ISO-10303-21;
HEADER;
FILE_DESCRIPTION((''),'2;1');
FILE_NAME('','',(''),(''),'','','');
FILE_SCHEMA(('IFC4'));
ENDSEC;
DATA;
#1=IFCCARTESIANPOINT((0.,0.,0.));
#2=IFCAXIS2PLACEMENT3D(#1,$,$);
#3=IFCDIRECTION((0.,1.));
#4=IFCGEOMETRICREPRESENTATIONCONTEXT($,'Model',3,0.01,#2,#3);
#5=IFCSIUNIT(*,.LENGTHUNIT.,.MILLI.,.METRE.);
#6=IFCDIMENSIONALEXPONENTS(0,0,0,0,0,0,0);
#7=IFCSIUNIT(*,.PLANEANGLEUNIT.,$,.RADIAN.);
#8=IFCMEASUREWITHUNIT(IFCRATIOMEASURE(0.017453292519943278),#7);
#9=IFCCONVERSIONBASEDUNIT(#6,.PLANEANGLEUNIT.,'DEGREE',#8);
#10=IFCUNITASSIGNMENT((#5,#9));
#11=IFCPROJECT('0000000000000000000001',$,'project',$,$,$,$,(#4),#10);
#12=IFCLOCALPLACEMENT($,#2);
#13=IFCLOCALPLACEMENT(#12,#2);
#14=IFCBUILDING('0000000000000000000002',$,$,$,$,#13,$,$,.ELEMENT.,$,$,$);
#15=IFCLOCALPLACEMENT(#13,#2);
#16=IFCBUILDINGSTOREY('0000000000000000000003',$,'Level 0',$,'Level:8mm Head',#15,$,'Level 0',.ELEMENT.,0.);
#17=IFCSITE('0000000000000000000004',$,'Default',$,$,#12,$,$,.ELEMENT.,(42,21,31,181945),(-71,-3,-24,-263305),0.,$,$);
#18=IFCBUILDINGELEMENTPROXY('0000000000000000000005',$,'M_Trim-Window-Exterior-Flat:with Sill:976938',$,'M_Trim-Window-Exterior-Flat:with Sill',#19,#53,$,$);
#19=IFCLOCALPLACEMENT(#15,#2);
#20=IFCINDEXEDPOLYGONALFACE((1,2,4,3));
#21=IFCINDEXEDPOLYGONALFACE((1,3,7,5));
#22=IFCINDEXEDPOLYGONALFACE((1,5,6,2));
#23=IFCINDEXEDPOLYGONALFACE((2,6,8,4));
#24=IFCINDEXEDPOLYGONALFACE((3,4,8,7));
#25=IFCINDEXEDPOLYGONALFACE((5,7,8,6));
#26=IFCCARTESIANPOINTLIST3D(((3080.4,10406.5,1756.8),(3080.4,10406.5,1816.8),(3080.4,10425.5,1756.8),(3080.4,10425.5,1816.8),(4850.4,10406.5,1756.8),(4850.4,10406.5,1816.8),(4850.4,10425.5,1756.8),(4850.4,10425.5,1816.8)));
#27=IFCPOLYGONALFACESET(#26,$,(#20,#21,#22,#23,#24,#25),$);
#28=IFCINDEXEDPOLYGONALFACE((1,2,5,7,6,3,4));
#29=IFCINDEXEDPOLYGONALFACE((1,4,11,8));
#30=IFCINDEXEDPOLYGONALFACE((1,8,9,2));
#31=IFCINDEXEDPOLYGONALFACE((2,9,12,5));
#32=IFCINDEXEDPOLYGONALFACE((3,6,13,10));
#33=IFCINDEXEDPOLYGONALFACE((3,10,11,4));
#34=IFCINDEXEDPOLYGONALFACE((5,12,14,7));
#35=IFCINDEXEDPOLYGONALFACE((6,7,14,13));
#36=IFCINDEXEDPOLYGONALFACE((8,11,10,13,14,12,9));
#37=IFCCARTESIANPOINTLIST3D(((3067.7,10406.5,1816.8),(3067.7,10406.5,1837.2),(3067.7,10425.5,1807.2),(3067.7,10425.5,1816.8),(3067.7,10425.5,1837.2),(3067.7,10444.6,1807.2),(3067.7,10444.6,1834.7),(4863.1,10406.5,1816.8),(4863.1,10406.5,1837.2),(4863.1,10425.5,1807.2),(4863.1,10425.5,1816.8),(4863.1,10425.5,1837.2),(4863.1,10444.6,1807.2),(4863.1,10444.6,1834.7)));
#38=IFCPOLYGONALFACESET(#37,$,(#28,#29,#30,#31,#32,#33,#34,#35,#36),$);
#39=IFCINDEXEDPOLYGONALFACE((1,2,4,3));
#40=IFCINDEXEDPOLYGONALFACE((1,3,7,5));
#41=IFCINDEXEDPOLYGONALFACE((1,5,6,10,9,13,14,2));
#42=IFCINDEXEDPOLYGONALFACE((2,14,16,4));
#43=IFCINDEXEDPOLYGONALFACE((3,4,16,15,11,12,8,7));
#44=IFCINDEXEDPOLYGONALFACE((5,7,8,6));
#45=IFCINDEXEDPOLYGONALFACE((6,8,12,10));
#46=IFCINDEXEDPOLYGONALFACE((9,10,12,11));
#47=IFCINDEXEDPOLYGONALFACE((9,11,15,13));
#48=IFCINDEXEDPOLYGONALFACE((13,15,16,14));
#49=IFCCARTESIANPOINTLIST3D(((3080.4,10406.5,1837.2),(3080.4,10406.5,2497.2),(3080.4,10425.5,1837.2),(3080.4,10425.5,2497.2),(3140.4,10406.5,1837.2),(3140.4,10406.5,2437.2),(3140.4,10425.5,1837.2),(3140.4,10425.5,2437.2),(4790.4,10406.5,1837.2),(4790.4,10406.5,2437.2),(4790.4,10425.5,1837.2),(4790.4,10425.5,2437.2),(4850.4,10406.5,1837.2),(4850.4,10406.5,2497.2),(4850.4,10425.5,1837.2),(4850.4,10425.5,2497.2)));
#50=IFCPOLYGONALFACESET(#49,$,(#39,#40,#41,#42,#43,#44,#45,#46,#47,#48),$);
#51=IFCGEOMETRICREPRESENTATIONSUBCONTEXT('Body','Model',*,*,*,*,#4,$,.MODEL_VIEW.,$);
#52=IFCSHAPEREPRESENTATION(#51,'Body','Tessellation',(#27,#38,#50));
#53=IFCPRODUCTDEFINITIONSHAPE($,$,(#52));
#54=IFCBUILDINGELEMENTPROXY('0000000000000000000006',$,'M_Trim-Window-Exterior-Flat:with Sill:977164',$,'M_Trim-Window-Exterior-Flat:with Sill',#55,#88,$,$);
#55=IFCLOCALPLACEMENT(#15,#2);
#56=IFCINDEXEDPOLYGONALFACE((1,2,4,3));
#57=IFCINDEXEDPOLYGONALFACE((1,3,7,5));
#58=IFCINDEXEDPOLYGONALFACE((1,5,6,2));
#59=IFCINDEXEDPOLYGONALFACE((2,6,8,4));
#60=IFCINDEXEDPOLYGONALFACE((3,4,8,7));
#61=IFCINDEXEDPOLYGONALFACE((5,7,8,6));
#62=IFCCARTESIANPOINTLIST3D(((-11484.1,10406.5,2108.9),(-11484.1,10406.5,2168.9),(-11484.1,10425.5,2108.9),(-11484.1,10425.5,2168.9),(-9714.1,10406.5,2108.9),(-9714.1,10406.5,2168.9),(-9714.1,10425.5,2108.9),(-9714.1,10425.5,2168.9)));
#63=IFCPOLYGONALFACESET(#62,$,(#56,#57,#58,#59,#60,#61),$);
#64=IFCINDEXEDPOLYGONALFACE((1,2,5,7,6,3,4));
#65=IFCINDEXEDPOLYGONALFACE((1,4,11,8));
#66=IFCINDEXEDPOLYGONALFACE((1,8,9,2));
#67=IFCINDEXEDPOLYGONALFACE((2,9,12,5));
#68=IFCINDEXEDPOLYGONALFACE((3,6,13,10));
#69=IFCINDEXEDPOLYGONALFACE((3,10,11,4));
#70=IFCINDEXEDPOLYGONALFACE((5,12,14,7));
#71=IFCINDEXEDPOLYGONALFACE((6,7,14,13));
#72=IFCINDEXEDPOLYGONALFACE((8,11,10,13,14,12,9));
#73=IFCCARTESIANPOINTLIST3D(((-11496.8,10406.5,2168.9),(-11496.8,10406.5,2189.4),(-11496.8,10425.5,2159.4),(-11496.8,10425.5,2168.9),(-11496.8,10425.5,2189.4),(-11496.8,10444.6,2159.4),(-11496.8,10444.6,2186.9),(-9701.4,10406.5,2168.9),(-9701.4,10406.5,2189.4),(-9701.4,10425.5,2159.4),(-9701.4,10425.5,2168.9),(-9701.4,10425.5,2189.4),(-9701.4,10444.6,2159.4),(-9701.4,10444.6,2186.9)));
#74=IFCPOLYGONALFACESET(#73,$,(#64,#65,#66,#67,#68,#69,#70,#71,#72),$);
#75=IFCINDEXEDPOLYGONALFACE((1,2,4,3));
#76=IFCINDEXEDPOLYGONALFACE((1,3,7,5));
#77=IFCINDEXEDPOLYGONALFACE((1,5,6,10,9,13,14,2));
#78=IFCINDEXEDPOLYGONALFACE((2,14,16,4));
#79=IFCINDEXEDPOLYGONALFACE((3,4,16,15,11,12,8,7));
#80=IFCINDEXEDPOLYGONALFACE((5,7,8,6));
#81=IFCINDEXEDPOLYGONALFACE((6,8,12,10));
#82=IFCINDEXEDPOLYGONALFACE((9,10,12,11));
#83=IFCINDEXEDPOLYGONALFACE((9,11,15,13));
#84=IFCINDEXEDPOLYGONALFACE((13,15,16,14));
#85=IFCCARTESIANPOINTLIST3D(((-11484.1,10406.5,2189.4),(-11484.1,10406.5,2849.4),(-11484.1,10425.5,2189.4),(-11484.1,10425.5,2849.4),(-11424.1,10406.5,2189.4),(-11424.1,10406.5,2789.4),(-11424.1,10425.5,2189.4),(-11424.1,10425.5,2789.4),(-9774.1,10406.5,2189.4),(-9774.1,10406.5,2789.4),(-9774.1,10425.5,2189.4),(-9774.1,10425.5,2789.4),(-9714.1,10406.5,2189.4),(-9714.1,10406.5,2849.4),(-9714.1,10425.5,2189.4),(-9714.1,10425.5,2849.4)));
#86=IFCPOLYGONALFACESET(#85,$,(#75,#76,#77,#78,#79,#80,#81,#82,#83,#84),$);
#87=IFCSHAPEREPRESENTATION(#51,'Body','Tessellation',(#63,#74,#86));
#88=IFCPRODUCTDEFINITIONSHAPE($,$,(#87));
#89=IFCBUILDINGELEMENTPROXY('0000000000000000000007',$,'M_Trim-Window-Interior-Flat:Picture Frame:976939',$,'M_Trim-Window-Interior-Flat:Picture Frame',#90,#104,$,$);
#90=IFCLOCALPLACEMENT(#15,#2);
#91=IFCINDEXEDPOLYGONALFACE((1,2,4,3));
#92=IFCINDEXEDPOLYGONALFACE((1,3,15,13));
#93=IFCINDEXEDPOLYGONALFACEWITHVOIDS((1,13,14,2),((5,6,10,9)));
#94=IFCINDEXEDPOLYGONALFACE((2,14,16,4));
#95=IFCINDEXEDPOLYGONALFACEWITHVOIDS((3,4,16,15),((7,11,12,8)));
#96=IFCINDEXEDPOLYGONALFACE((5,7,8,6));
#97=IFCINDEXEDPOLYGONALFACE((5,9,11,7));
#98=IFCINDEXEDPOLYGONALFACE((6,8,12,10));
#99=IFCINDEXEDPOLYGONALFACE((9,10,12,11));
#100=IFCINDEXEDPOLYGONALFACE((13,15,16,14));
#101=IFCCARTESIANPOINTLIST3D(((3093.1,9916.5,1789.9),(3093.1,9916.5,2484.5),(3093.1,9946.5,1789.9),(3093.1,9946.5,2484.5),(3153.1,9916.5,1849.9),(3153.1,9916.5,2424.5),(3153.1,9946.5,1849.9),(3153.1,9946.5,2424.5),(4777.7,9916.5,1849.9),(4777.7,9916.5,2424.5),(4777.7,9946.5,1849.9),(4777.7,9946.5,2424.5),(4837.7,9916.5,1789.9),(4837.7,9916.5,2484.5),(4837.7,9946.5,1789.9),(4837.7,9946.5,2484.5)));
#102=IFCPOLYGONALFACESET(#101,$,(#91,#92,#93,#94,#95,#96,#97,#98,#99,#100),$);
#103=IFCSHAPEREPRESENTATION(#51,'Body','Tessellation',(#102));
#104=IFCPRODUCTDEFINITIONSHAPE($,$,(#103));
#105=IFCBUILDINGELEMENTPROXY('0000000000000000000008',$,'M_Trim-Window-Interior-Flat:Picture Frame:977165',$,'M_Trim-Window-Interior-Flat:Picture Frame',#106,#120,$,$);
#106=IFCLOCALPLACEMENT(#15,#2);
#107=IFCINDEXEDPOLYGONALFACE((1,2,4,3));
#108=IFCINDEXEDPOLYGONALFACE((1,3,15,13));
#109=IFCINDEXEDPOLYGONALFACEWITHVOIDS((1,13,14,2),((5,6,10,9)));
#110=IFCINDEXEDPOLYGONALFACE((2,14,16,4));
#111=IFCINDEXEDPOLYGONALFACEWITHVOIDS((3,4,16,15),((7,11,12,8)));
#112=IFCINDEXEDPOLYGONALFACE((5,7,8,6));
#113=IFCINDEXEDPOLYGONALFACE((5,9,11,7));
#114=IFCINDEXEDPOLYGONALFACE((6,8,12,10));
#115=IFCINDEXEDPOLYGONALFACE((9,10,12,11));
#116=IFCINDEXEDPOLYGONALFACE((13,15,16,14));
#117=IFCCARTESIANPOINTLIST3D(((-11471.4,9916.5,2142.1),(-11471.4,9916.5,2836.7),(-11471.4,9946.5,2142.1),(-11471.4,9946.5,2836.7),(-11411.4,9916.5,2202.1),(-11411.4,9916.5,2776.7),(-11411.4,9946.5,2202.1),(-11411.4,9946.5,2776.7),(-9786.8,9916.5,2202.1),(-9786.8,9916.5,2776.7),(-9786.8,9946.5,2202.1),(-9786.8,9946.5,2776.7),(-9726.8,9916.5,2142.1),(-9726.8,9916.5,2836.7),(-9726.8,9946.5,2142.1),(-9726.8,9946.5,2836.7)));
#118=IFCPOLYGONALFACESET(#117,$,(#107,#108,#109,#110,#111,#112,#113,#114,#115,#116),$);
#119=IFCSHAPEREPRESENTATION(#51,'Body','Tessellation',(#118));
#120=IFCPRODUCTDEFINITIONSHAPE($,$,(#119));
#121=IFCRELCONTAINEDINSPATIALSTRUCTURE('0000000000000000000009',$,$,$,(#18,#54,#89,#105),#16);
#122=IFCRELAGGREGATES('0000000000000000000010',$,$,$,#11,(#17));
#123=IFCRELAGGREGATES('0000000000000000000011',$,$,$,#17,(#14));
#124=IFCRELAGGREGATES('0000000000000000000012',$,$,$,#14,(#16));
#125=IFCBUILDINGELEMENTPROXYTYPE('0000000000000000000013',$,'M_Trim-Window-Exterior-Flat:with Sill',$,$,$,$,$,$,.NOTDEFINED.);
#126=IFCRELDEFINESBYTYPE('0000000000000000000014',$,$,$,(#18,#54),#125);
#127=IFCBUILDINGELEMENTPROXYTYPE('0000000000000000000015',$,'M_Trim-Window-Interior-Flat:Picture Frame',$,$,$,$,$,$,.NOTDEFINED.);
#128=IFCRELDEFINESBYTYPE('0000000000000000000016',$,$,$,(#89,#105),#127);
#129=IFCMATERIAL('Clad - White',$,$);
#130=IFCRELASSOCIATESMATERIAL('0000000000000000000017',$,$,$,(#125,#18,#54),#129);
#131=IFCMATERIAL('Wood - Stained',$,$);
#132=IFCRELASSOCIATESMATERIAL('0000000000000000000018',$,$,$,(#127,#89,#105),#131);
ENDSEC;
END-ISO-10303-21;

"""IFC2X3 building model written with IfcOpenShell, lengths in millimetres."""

from ifc_helpers import new_model, entity, si_unit, converted_unit, direction, frame, frame_2d, origin, place, context, subcontext, project, spatial, polyline, rectangle, outline, extrude, source, transform, mapped, material, type_object, type_shapes, element, save


model = new_model("IFC2X3")

# Units and contexts
model_context = context("Model", 3, precision=0.01, world=origin(), true_north=direction((0.0, 1.0)))
body_context = subcontext(model_context, "Body", "Model", "MODEL_VIEW")
ifc_project = project(units=[si_unit("LENGTHUNIT", "METRE", prefix="MILLI"), converted_unit("PLANEANGLEUNIT", "DEGREE", entity("IfcRatioMeasure", 0.017453292519943278), si_unit("PLANEANGLEUNIT", "RADIAN"), dimensions=[0, 0, 0, 0, 0, 0, 0])], contexts=[model_context])

# Site, building, storey
site_placement = place(None, origin())
site = spatial("IfcSite", under=ifc_project, at=site_placement, Name="Default", CompositionType="ELEMENT", RefLatitude=(42, 21, 31, 181945), RefLongitude=(-71, -3, -24, -263305), RefElevation=0.0)
building_placement = place(site_placement, origin())
building = spatial("IfcBuilding", under=site, at=building_placement, CompositionType="ELEMENT")
storey_placement = place(building_placement, origin())
storey = spatial("IfcBuildingStorey", under=building, at=storey_placement, Name="Level 0", ObjectType="Level:8mm Head", LongName="Level 0", CompositionType="ELEMENT", Elevation=0.0)

# Building element proxies
ifc_material_1 = material(Name="Clad - White")
ifc_material_2 = material(Name="Wood - Stained")
building_element_proxy_type_1 = type_object("IfcBuildingElementProxyType", Name="M_Trim-Window-Exterior-Flat:with Sill", PredefinedType="NOTDEFINED", material=ifc_material_1)
shared_shape_1 = source(origin(), body_context, "Body", "SweptSolid", [
    extrude(rectangle(XDim=1770.0, YDim=60.0, at=frame_2d((0.0, 0.0), x_axis=(1.0, 0.0))), frame((0.0, -650.4, 0.0), z_axis=(0.0, 0.0, 1.0), x_axis=(-1.0, 0.0, 0.0)), (0.0, 0.0, 1.0), 19.0),
    extrude(outline(polyline([(-19.0, -15.2), (0.0, -15.2), (0.0, -5.7), (19.0, -5.7), (19.0, 14.8), (0.0, 14.8), (-19.0, 12.3), (-19.0, -15.2)])), frame((-897.7, -614.8, 19.0), z_axis=(1.0, 0.0, 0.0), x_axis=(0.0, 0.0, -1.0)), (0.0, 0.0, 1.0), 1795.4),
    extrude(outline(polyline([(-345.0, -885.0), (315.0, -885.0), (315.0, -825.0), (-285.0, -825.0), (-285.0, 825.0), (315.0, 825.0), (315.0, 885.0), (-345.0, 885.0), (-345.0, -885.0)])), frame((0.0, -285.0, 0.0), z_axis=(0.0, 0.0, 1.0), x_axis=(0.0, -1.0, 0.0)), (0.0, 0.0, 1.0), 19.0),
])
type_shapes(building_element_proxy_type_1, [shared_shape_1])
for number, where, z_axis, x_axis, name in (
    (1, (3965.4, 10406.5, 2437.2), (0.0, 1.0, 0.0), (-1.0, 0.0, 0.0), "M_Trim-Window-Exterior-Flat:with Sill:976938"),
    (2, (-10599.1, 10406.5, 2789.4), (0.0, 1.0, 0.0), (-1.0, 0.0, 0.0), "M_Trim-Window-Exterior-Flat:with Sill:977164"),
):
    element("IfcBuildingElementProxy", number, at=place(storey_placement, frame(where, z_axis=z_axis, x_axis=x_axis)), inside=storey, type_object=building_element_proxy_type_1, material=ifc_material_1, Name=name, ObjectType="M_Trim-Window-Exterior-Flat:with Sill", context=body_context, shape_type="MappedRepresentation", body=[
        mapped(shared_shape_1, transform((0.0, 0.0, 0.0), scale=1.0)),
    ])
building_element_proxy_type_2 = type_object("IfcBuildingElementProxyType", Name="M_Trim-Window-Interior-Flat:Picture Frame", PredefinedType="NOTDEFINED", material=ifc_material_2)
shared_shape_2 = source(origin(), body_context, "Body", "SweptSolid", [
    extrude(outline(polyline([(-872.3, -347.3), (872.3, -347.3), (872.3, 347.3), (-872.3, 347.3), (-872.3, -347.3)]), holes=[polyline([(-812.3, -287.3), (-812.3, 287.3), (812.3, 287.3), (812.3, -287.3), (-812.3, -287.3)])]), frame((0.0, -300.0, 0.0), z_axis=(0.0, 0.0, 1.0), x_axis=(-1.0, 0.0, 0.0)), (0.0, 0.0, 1.0), 30.0),
])
type_shapes(building_element_proxy_type_2, [shared_shape_2])
for number, where, z_axis, x_axis, name in (
    (3, (3965.4, 9946.5, 2437.2), (0.0, -1.0, 0.0), (1.0, 0.0, 0.0), "M_Trim-Window-Interior-Flat:Picture Frame:976939"),
    (4, (-10599.1, 9946.5, 2789.4), (0.0, -1.0, 0.0), (1.0, 0.0, 0.0), "M_Trim-Window-Interior-Flat:Picture Frame:977165"),
):
    element("IfcBuildingElementProxy", number, at=place(storey_placement, frame(where, z_axis=z_axis, x_axis=x_axis)), inside=storey, type_object=building_element_proxy_type_2, material=ifc_material_2, Name=name, ObjectType="M_Trim-Window-Interior-Flat:Picture Frame", context=body_context, shape_type="MappedRepresentation", body=[
        mapped(shared_shape_2, transform((0.0, 0.0, 0.0), scale=1.0)),
    ])

save(model, "model.ifc")
